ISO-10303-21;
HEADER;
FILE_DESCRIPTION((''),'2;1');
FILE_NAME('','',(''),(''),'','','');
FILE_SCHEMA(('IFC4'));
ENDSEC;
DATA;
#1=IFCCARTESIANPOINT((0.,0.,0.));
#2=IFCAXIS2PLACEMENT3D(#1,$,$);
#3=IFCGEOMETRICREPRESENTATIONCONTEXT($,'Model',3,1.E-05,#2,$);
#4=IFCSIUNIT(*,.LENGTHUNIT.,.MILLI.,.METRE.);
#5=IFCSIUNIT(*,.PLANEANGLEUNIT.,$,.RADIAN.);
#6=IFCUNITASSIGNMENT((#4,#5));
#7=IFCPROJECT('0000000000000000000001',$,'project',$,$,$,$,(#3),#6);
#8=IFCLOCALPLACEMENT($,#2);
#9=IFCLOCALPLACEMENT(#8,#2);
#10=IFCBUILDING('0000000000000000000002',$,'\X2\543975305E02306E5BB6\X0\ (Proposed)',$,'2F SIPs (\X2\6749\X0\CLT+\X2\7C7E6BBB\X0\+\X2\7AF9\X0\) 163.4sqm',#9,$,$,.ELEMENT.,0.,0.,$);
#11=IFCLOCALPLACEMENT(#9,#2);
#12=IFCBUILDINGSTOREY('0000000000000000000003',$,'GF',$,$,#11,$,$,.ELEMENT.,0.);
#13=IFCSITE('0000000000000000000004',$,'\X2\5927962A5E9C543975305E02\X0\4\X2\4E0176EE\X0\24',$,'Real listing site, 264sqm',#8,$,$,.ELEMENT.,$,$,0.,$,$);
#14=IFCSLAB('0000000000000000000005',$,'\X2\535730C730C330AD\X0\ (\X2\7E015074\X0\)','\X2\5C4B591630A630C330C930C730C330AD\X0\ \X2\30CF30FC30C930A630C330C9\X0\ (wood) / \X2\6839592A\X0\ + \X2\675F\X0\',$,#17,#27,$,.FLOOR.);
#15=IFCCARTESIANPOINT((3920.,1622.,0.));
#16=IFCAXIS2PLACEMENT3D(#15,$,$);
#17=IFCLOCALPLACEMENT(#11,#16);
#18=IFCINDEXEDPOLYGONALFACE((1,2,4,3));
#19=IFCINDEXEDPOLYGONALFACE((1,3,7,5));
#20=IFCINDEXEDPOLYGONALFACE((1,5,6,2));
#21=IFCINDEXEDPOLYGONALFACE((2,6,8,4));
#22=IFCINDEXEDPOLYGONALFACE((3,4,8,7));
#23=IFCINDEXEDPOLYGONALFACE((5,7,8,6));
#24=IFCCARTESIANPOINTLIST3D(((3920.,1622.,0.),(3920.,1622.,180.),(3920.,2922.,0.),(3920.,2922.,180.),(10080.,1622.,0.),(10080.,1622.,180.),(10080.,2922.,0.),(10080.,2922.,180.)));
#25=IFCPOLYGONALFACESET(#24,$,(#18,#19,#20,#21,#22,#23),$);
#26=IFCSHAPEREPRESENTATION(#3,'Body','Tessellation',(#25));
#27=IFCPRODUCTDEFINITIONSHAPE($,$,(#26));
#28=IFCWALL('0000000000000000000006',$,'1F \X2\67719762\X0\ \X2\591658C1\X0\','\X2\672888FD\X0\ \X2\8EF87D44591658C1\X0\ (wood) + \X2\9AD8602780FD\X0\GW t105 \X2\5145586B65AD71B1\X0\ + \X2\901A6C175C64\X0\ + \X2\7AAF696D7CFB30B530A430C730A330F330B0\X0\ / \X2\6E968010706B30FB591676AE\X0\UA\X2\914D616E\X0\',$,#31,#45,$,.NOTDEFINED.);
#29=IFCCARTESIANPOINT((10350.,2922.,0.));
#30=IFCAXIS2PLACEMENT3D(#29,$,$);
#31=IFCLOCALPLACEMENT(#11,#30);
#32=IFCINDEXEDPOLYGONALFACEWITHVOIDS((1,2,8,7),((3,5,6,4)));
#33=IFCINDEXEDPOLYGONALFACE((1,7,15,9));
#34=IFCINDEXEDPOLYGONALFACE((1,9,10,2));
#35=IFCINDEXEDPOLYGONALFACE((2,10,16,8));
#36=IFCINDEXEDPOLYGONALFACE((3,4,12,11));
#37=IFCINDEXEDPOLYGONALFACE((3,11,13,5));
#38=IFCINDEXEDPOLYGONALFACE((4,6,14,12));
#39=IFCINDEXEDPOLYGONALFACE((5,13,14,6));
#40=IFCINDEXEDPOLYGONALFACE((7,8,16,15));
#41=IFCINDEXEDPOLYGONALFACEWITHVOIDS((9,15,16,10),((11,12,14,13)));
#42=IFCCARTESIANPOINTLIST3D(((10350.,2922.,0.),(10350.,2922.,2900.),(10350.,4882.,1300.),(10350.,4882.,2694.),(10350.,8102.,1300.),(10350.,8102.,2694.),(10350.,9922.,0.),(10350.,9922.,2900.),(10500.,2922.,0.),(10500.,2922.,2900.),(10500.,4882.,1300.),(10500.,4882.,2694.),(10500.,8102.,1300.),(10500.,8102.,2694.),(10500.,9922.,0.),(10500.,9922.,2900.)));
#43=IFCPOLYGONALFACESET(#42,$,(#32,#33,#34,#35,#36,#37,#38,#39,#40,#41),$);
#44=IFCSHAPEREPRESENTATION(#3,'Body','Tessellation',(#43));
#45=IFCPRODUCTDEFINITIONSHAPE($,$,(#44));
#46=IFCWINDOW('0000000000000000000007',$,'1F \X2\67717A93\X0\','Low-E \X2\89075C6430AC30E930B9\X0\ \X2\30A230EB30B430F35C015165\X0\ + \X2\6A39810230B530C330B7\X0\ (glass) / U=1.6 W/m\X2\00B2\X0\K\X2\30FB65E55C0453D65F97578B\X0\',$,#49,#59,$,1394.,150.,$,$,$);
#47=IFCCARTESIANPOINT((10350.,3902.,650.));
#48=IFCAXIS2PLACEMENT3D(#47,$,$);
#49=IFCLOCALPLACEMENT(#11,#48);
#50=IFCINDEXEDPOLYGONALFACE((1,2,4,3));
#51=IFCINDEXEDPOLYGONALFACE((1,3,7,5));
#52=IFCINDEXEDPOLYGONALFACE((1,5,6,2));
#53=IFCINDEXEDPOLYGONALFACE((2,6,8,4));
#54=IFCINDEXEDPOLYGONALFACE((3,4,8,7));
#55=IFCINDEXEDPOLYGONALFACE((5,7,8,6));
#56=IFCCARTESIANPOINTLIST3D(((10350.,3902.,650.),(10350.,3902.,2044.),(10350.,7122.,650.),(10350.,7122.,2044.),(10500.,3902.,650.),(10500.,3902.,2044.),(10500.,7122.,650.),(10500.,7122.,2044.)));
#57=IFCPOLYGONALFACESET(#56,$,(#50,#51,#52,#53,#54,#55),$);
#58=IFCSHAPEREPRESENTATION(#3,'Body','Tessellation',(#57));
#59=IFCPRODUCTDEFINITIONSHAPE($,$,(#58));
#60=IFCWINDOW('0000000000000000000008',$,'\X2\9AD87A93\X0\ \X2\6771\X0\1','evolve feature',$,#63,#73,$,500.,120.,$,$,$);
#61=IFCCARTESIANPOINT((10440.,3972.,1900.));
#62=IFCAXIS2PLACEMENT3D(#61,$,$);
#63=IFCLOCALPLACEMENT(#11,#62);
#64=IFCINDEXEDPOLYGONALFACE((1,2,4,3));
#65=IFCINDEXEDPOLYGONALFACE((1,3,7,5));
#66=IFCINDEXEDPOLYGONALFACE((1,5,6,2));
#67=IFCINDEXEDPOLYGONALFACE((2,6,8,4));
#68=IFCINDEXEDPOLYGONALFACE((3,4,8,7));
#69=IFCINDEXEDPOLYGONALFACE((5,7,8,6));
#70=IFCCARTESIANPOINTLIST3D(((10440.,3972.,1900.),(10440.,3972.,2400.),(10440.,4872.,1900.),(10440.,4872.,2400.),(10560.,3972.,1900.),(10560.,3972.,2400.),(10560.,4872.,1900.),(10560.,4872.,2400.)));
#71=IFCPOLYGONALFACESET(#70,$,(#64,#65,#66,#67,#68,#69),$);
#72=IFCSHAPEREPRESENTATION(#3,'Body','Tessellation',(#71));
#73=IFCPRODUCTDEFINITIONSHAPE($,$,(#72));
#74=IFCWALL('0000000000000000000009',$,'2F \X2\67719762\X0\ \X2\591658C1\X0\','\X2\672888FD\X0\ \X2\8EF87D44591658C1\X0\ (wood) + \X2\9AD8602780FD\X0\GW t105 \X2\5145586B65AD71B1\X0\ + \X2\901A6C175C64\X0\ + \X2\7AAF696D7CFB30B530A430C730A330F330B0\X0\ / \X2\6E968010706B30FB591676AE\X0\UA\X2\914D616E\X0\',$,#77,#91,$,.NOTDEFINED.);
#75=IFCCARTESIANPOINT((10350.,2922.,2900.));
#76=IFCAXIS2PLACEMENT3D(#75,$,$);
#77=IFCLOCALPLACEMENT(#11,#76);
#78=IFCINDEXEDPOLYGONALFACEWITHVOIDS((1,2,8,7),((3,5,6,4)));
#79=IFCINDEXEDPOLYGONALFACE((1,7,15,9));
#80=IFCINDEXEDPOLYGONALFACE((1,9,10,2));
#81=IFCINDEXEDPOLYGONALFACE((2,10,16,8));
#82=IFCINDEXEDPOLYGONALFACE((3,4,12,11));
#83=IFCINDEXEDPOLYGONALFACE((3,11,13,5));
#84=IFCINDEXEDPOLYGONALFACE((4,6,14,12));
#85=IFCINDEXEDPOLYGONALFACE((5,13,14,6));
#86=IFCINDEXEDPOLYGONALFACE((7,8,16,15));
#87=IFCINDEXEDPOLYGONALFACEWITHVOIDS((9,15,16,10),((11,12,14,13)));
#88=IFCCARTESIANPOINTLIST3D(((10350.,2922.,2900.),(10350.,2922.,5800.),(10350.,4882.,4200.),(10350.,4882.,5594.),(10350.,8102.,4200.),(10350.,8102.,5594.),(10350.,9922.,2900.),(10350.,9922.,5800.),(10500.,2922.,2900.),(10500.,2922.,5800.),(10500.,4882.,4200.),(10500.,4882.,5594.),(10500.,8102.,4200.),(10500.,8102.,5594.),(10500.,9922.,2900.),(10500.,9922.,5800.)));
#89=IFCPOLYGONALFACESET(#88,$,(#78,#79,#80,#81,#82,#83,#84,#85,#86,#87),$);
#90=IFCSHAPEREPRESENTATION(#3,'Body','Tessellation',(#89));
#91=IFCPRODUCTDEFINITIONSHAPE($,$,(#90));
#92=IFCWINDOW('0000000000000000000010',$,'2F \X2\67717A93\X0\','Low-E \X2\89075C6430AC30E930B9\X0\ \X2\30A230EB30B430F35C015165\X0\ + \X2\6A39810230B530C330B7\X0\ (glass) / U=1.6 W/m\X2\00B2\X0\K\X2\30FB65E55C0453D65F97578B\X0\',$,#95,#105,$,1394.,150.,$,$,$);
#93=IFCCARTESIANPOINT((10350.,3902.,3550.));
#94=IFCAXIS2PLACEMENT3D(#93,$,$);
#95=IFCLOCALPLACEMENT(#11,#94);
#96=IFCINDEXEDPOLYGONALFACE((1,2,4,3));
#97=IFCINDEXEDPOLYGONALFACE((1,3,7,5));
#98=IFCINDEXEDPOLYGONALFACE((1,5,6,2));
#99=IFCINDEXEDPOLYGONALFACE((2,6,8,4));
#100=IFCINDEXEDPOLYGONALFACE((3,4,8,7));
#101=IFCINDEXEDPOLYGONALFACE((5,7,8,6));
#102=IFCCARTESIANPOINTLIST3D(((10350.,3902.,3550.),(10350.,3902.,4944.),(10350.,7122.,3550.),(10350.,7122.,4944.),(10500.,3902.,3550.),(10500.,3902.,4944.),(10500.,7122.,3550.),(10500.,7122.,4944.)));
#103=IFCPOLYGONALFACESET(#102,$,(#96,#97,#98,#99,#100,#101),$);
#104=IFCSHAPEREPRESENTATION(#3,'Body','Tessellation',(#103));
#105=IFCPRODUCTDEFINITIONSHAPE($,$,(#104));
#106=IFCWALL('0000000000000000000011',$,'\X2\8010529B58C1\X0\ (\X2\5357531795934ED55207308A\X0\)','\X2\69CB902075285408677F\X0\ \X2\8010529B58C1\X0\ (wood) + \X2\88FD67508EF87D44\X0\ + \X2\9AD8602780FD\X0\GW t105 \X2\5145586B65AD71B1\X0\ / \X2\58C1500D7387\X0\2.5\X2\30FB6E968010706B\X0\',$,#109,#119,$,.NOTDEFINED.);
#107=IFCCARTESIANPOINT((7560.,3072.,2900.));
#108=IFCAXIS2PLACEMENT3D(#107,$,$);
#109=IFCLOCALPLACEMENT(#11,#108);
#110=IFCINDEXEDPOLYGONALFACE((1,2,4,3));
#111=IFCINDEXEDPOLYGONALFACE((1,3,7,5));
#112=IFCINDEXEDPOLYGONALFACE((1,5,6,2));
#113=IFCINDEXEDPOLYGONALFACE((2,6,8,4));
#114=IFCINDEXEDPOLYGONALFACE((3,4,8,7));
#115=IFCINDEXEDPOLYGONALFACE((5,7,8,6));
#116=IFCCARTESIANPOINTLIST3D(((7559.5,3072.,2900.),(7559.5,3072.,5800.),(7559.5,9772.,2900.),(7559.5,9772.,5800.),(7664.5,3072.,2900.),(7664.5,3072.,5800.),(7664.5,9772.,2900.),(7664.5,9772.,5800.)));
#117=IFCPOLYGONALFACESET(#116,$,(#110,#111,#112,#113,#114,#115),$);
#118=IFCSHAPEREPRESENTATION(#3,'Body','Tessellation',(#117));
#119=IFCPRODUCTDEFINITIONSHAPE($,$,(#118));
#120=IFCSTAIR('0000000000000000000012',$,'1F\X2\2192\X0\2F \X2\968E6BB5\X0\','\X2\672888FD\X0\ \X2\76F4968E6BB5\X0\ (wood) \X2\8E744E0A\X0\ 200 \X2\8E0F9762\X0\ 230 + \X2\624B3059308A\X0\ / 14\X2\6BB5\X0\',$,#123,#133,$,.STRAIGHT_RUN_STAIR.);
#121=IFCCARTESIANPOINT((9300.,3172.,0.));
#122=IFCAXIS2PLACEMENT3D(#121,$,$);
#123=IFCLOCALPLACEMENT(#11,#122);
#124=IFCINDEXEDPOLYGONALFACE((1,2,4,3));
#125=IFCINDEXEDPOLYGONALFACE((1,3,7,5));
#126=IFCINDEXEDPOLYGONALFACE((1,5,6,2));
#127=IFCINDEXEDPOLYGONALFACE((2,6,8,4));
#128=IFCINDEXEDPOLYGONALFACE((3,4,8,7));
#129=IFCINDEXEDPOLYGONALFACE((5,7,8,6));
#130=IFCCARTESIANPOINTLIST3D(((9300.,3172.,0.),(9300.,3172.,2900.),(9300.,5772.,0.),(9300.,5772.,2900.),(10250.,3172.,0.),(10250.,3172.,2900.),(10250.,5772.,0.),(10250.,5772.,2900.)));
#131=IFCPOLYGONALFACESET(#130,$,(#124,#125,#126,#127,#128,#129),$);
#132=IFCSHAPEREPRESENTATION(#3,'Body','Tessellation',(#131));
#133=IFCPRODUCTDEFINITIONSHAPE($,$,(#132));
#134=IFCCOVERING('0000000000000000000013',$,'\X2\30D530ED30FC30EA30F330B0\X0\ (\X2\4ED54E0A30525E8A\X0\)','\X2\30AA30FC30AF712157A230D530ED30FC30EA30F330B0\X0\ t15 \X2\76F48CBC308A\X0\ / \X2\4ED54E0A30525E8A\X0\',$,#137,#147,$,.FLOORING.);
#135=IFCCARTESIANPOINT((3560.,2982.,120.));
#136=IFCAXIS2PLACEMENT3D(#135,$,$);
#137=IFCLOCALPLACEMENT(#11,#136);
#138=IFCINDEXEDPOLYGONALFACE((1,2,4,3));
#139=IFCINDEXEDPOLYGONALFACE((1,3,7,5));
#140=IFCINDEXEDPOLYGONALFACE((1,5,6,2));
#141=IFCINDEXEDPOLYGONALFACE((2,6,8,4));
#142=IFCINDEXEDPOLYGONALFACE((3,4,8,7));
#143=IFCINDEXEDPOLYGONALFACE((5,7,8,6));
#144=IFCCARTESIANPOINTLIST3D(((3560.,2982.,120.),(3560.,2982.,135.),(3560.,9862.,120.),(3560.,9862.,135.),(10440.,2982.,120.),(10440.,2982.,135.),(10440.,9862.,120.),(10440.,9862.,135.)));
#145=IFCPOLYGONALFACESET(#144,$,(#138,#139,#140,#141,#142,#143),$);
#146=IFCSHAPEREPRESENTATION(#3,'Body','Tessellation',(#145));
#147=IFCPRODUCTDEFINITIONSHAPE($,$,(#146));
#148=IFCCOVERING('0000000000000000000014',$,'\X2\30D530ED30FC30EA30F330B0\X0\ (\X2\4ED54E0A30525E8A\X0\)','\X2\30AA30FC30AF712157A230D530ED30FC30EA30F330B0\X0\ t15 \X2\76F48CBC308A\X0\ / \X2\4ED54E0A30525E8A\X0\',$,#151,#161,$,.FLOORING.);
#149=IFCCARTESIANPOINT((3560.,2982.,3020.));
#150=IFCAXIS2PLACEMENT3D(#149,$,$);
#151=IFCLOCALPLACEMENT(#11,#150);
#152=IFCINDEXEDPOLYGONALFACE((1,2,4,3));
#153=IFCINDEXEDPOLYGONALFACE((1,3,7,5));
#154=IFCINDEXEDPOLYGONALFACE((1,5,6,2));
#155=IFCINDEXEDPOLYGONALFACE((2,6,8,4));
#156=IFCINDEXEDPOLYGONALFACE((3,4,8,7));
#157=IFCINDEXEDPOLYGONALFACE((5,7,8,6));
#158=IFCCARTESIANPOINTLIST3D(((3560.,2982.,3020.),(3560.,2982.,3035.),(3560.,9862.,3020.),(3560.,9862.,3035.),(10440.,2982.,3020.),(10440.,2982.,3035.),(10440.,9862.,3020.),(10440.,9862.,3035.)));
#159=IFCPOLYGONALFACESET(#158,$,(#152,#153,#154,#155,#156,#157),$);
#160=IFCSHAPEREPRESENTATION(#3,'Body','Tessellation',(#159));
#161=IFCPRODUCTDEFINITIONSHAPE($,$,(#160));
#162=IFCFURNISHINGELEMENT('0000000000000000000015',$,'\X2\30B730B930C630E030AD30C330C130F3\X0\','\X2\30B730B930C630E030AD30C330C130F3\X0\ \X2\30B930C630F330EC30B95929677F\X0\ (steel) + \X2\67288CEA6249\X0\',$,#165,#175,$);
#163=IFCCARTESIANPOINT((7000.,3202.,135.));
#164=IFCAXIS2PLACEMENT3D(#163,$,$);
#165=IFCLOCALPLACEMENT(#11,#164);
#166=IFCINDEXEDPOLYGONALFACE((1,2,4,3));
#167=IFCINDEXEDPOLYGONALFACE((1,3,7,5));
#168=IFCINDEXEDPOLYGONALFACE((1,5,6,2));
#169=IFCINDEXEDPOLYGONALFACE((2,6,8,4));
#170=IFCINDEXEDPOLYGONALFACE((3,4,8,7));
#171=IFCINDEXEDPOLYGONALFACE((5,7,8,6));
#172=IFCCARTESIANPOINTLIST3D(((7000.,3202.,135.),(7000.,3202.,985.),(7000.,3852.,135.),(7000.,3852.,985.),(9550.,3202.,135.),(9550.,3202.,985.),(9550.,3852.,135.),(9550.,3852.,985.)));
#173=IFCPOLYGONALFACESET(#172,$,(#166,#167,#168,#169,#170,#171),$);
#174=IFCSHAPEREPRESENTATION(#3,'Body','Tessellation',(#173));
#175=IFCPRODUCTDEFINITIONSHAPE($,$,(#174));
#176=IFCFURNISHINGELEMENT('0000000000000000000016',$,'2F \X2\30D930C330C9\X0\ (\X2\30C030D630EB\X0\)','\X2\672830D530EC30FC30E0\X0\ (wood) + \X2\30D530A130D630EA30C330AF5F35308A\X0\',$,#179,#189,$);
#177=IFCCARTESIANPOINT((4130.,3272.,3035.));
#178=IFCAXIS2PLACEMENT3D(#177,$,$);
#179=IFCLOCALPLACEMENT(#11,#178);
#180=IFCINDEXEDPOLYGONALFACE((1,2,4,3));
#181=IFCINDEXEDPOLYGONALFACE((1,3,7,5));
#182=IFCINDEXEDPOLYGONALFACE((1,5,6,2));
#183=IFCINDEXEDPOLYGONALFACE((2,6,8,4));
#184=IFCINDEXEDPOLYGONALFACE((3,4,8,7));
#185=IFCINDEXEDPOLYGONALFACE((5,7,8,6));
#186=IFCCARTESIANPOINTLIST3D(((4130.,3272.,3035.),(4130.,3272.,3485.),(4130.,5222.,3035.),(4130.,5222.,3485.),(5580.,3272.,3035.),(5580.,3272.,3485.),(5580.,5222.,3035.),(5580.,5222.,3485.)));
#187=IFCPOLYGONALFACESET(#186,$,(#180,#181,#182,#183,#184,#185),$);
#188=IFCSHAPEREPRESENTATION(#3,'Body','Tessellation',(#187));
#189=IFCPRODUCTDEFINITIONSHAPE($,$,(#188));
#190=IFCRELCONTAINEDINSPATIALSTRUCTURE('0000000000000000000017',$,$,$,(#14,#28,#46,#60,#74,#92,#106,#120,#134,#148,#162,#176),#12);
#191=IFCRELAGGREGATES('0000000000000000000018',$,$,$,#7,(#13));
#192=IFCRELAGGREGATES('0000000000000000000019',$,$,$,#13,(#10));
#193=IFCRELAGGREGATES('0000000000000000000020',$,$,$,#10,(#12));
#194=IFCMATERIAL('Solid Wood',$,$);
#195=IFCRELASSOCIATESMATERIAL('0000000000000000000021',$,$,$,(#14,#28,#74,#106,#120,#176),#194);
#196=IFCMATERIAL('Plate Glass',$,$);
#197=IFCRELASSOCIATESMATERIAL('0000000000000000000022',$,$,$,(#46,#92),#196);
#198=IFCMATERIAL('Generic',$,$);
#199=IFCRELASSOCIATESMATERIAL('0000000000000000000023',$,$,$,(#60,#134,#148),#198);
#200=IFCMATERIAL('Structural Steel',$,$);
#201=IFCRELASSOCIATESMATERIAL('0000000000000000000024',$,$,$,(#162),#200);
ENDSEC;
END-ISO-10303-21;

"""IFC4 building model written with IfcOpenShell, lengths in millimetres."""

from ifc_helpers import new_model, si_unit, frame, frame_2d, origin, place, context, project, spatial, rectangle, extrude, material, element, fill, save


model = new_model("IFC4")

# Units and contexts
model_context = context("Model", 3, precision=1e-05, world=origin())
ifc_project = project(units=[si_unit("LENGTHUNIT", "METRE", prefix="MILLI"), si_unit("PLANEANGLEUNIT", "RADIAN")], contexts=[model_context])

# Site, building, storey
site_placement = place(None, origin())
site = spatial("IfcSite", under=ifc_project, at=site_placement, Name="大阪府吹田市4丁目24", ObjectType="Real listing site, 264sqm", CompositionType="ELEMENT", RefElevation=0.0)
building_placement = place(site_placement, origin())
building = spatial("IfcBuilding", under=site, at=building_placement, Name="吹田市の家 (Proposed)", ObjectType="2F SIPs (杉CLT+籾殻+竹) 163.4sqm", CompositionType="ELEMENT", ElevationOfRefHeight=0.0, ElevationOfTerrain=0.0)
storey_placement = place(building_placement, origin())
storey = spatial("IfcBuildingStorey", under=building, at=storey_placement, Name="GF", CompositionType="ELEMENT", Elevation=0.0)

# Slab
ifc_material_1 = material(Name="Solid Wood")
slab_placement = place(storey_placement, frame((3920.0, 1622.0, 0.0)))
element("IfcSlab", 1, at=slab_placement, inside=storey, material=ifc_material_1, Name="南デッキ (縁側)", Description="屋外ウッドデッキ ハードウッド (wood) / 根太 + 束", PredefinedType="FLOOR", context=model_context, shape_type="SweptSolid", body=[
    extrude(rectangle(XDim=6160.0, YDim=1300.0, at=frame_2d((3080.0, 650.0))), frame((3920.0, 1622.0, 0.0)), (0.0, 0.0, 1.0), 180.0),
])

# Wall, openings, windows
wall_1_placement = place(storey_placement, frame((10350.0, 2922.0, 0.0)))
wall_1 = element("IfcWall", 2, at=wall_1_placement, inside=storey, material=ifc_material_1, Name="1F 東面 外壁", Description="木製 軸組外壁 (wood) + 高性能GW t105 充填断熱 + 通気層 + 窯業系サイディング / 準耐火・外皮UA配慮", PredefinedType="NOTDEFINED", context=model_context, shape_type="SweptSolid", body=[
    extrude(rectangle(XDim=150.0, YDim=7000.0, at=frame_2d((75.0, 3500.0))), frame((10350.0, 2922.0, 0.0)), (0.0, 0.0, 1.0), 2900.0),
])
opening_1_placement = place(storey_placement, frame((10350.0, 3902.0, 650.0)))
opening_1 = element("IfcOpeningElement", 3, at=opening_1_placement, cuts=wall_1, PredefinedType="NOTDEFINED", context=model_context, shape_type="SweptSolid", body=[
    extrude(rectangle(XDim=150.0, YDim=3220.0, at=frame_2d((75.0, 1610.0))), frame((10350.0, 3902.0, 650.0)), (0.0, 0.0, 1.0), 1394.0),
])
opening_2_placement = place(storey_placement, frame((10440.0, 3972.0, 1900.0)))
opening_2 = element("IfcOpeningElement", 4, at=opening_2_placement, cuts=wall_1, PredefinedType="NOTDEFINED", context=model_context, shape_type="SweptSolid", body=[
    extrude(rectangle(XDim=120.0, YDim=900.0, at=frame_2d((60.0, 450.0))), frame((10440.0, 3972.0, 1900.0)), (0.0, 0.0, 1.0), 500.0),
])
ifc_material_2 = material(Name="Plate Glass")
window_1_placement = place(storey_placement, frame((10350.0, 3902.0, 650.0)))
window_1 = element("IfcWindow", 5, at=window_1_placement, inside=storey, material=ifc_material_2, Name="1F 東窓", Description="Low-E 複層ガラス アルゴン封入 + 樹脂サッシ (glass) / U=1.6 W/m²K・日射取得型", OverallHeight=1394.0, OverallWidth=150.0, context=model_context, shape_type="SweptSolid", body=[
    extrude(rectangle(XDim=150.0, YDim=3220.0, at=frame_2d((75.0, 1610.0))), frame((10350.0, 3902.0, 650.0)), (0.0, 0.0, 1.0), 1394.0),
])
fill(opening_1, window_1)
ifc_material_3 = material(Name="Generic")
window_2_placement = place(storey_placement, frame((10440.0, 3972.0, 1900.0)))
window_2 = element("IfcWindow", 6, at=window_2_placement, inside=storey, material=ifc_material_3, Name="高窓 東1", Description="evolve feature", OverallHeight=500.0, OverallWidth=120.0, context=model_context, shape_type="SweptSolid", body=[
    extrude(rectangle(XDim=120.0, YDim=900.0, at=frame_2d((60.0, 450.0))), frame((10440.0, 3972.0, 1900.0)), (0.0, 0.0, 1.0), 500.0),
])
fill(opening_2, window_2)

# Wall, opening, window
wall_2_placement = place(storey_placement, frame((10350.0, 2922.0, 2900.0)))
wall_2 = element("IfcWall", 7, at=wall_2_placement, inside=storey, material=ifc_material_1, Name="2F 東面 外壁", Description="木製 軸組外壁 (wood) + 高性能GW t105 充填断熱 + 通気層 + 窯業系サイディング / 準耐火・外皮UA配慮", PredefinedType="NOTDEFINED", context=model_context, shape_type="SweptSolid", body=[
    extrude(rectangle(XDim=150.0, YDim=7000.0, at=frame_2d((75.0, 3500.0))), frame((10350.0, 2922.0, 2900.0)), (0.0, 0.0, 1.0), 2900.0),
])
opening_3_placement = place(storey_placement, frame((10350.0, 3902.0, 3550.0)))
opening_3 = element("IfcOpeningElement", 8, at=opening_3_placement, cuts=wall_2, PredefinedType="NOTDEFINED", context=model_context, shape_type="SweptSolid", body=[
    extrude(rectangle(XDim=150.0, YDim=3220.0, at=frame_2d((75.0, 1610.0))), frame((10350.0, 3902.0, 3550.0)), (0.0, 0.0, 1.0), 1394.0),
])
window_3_placement = place(storey_placement, frame((10350.0, 3902.0, 3550.0)))
window_3 = element("IfcWindow", 9, at=window_3_placement, inside=storey, material=ifc_material_2, Name="2F 東窓", Description="Low-E 複層ガラス アルゴン封入 + 樹脂サッシ (glass) / U=1.6 W/m²K・日射取得型", OverallHeight=1394.0, OverallWidth=150.0, context=model_context, shape_type="SweptSolid", body=[
    extrude(rectangle(XDim=150.0, YDim=3220.0, at=frame_2d((75.0, 1610.0))), frame((10350.0, 3902.0, 3550.0)), (0.0, 0.0, 1.0), 1394.0),
])
fill(opening_3, window_3)

# Wall
wall_3_placement = place(storey_placement, frame((7560.0, 3072.0, 2900.0)))
element("IfcWall", 10, at=wall_3_placement, inside=storey, material=ifc_material_1, Name="耐力壁 (南北間仕切り)", Description="構造用合板 耐力壁 (wood) + 製材軸組 + 高性能GW t105 充填断熱 / 壁倍率2.5・準耐火", PredefinedType="NOTDEFINED", context=model_context, shape_type="SweptSolid", body=[
    extrude(rectangle(XDim=105.0, YDim=6700.0, at=frame_2d((52.0, 3350.0))), frame((7560.0, 3072.0, 2900.0)), (0.0, 0.0, 1.0), 2900.0),
])

# Stair
stair_placement = place(storey_placement, frame((9300.0, 3172.0, 0.0)))
element("IfcStair", 11, at=stair_placement, inside=storey, material=ifc_material_1, Name="1F→2F 階段", Description="木製 直階段 (wood) 蹴上 200 踏面 230 + 手すり / 14段", PredefinedType="STRAIGHT_RUN_STAIR", context=model_context, shape_type="SweptSolid", body=[
    extrude(rectangle(XDim=950.0, YDim=2600.0, at=frame_2d((475.0, 1300.0))), frame((9300.0, 3172.0, 0.0)), (0.0, 0.0, 1.0), 2900.0),
])

# Coverings
covering_1_placement = place(storey_placement, frame((3560.0, 2982.0, 120.0)))
element("IfcCovering", 12, at=covering_1_placement, inside=storey, material=ifc_material_3, Name="フローリング (仕上げ床)", Description="オーク無垢フローリング t15 直貼り / 仕上げ床", PredefinedType="FLOORING", context=model_context, shape_type="SweptSolid", body=[
    extrude(rectangle(XDim=6880.0, YDim=6880.0, at=frame_2d((3440.0, 3440.0))), frame((3560.0, 2982.0, 120.0)), (0.0, 0.0, 1.0), 15.0),
])
covering_2_placement = place(storey_placement, frame((3560.0, 2982.0, 3020.0)))
element("IfcCovering", 13, at=covering_2_placement, inside=storey, material=ifc_material_3, Name="フローリング (仕上げ床)", Description="オーク無垢フローリング t15 直貼り / 仕上げ床", PredefinedType="FLOORING", context=model_context, shape_type="SweptSolid", body=[
    extrude(rectangle(XDim=6880.0, YDim=6880.0, at=frame_2d((3440.0, 3440.0))), frame((3560.0, 2982.0, 3020.0)), (0.0, 0.0, 1.0), 15.0),
])

# Furnishing elements
ifc_material_4 = material(Name="Structural Steel")
furnishing_1_placement = place(storey_placement, frame((7000.0, 3202.0, 135.0)))
element("IfcFurnishingElement", 14, at=furnishing_1_placement, inside=storey, material=ifc_material_4, Name="システムキッチン", Description="システムキッチン ステンレス天板 (steel) + 木質扉", context=model_context, shape_type="SweptSolid", body=[
    extrude(rectangle(XDim=2550.0, YDim=650.0, at=frame_2d((1275.0, 325.0))), frame((7000.0, 3202.0, 135.0)), (0.0, 0.0, 1.0), 850.0),
])
furnishing_2_placement = place(storey_placement, frame((4130.0, 3272.0, 3035.0)))
element("IfcFurnishingElement", 15, at=furnishing_2_placement, inside=storey, material=ifc_material_1, Name="2F ベッド (ダブル)", Description="木フレーム (wood) + ファブリック張り", context=model_context, shape_type="SweptSolid", body=[
    extrude(rectangle(XDim=1450.0, YDim=1950.0, at=frame_2d((725.0, 975.0))), frame((4130.0, 3272.0, 3035.0)), (0.0, 0.0, 1.0), 450.0),
])

save(model, "model.ifc")
